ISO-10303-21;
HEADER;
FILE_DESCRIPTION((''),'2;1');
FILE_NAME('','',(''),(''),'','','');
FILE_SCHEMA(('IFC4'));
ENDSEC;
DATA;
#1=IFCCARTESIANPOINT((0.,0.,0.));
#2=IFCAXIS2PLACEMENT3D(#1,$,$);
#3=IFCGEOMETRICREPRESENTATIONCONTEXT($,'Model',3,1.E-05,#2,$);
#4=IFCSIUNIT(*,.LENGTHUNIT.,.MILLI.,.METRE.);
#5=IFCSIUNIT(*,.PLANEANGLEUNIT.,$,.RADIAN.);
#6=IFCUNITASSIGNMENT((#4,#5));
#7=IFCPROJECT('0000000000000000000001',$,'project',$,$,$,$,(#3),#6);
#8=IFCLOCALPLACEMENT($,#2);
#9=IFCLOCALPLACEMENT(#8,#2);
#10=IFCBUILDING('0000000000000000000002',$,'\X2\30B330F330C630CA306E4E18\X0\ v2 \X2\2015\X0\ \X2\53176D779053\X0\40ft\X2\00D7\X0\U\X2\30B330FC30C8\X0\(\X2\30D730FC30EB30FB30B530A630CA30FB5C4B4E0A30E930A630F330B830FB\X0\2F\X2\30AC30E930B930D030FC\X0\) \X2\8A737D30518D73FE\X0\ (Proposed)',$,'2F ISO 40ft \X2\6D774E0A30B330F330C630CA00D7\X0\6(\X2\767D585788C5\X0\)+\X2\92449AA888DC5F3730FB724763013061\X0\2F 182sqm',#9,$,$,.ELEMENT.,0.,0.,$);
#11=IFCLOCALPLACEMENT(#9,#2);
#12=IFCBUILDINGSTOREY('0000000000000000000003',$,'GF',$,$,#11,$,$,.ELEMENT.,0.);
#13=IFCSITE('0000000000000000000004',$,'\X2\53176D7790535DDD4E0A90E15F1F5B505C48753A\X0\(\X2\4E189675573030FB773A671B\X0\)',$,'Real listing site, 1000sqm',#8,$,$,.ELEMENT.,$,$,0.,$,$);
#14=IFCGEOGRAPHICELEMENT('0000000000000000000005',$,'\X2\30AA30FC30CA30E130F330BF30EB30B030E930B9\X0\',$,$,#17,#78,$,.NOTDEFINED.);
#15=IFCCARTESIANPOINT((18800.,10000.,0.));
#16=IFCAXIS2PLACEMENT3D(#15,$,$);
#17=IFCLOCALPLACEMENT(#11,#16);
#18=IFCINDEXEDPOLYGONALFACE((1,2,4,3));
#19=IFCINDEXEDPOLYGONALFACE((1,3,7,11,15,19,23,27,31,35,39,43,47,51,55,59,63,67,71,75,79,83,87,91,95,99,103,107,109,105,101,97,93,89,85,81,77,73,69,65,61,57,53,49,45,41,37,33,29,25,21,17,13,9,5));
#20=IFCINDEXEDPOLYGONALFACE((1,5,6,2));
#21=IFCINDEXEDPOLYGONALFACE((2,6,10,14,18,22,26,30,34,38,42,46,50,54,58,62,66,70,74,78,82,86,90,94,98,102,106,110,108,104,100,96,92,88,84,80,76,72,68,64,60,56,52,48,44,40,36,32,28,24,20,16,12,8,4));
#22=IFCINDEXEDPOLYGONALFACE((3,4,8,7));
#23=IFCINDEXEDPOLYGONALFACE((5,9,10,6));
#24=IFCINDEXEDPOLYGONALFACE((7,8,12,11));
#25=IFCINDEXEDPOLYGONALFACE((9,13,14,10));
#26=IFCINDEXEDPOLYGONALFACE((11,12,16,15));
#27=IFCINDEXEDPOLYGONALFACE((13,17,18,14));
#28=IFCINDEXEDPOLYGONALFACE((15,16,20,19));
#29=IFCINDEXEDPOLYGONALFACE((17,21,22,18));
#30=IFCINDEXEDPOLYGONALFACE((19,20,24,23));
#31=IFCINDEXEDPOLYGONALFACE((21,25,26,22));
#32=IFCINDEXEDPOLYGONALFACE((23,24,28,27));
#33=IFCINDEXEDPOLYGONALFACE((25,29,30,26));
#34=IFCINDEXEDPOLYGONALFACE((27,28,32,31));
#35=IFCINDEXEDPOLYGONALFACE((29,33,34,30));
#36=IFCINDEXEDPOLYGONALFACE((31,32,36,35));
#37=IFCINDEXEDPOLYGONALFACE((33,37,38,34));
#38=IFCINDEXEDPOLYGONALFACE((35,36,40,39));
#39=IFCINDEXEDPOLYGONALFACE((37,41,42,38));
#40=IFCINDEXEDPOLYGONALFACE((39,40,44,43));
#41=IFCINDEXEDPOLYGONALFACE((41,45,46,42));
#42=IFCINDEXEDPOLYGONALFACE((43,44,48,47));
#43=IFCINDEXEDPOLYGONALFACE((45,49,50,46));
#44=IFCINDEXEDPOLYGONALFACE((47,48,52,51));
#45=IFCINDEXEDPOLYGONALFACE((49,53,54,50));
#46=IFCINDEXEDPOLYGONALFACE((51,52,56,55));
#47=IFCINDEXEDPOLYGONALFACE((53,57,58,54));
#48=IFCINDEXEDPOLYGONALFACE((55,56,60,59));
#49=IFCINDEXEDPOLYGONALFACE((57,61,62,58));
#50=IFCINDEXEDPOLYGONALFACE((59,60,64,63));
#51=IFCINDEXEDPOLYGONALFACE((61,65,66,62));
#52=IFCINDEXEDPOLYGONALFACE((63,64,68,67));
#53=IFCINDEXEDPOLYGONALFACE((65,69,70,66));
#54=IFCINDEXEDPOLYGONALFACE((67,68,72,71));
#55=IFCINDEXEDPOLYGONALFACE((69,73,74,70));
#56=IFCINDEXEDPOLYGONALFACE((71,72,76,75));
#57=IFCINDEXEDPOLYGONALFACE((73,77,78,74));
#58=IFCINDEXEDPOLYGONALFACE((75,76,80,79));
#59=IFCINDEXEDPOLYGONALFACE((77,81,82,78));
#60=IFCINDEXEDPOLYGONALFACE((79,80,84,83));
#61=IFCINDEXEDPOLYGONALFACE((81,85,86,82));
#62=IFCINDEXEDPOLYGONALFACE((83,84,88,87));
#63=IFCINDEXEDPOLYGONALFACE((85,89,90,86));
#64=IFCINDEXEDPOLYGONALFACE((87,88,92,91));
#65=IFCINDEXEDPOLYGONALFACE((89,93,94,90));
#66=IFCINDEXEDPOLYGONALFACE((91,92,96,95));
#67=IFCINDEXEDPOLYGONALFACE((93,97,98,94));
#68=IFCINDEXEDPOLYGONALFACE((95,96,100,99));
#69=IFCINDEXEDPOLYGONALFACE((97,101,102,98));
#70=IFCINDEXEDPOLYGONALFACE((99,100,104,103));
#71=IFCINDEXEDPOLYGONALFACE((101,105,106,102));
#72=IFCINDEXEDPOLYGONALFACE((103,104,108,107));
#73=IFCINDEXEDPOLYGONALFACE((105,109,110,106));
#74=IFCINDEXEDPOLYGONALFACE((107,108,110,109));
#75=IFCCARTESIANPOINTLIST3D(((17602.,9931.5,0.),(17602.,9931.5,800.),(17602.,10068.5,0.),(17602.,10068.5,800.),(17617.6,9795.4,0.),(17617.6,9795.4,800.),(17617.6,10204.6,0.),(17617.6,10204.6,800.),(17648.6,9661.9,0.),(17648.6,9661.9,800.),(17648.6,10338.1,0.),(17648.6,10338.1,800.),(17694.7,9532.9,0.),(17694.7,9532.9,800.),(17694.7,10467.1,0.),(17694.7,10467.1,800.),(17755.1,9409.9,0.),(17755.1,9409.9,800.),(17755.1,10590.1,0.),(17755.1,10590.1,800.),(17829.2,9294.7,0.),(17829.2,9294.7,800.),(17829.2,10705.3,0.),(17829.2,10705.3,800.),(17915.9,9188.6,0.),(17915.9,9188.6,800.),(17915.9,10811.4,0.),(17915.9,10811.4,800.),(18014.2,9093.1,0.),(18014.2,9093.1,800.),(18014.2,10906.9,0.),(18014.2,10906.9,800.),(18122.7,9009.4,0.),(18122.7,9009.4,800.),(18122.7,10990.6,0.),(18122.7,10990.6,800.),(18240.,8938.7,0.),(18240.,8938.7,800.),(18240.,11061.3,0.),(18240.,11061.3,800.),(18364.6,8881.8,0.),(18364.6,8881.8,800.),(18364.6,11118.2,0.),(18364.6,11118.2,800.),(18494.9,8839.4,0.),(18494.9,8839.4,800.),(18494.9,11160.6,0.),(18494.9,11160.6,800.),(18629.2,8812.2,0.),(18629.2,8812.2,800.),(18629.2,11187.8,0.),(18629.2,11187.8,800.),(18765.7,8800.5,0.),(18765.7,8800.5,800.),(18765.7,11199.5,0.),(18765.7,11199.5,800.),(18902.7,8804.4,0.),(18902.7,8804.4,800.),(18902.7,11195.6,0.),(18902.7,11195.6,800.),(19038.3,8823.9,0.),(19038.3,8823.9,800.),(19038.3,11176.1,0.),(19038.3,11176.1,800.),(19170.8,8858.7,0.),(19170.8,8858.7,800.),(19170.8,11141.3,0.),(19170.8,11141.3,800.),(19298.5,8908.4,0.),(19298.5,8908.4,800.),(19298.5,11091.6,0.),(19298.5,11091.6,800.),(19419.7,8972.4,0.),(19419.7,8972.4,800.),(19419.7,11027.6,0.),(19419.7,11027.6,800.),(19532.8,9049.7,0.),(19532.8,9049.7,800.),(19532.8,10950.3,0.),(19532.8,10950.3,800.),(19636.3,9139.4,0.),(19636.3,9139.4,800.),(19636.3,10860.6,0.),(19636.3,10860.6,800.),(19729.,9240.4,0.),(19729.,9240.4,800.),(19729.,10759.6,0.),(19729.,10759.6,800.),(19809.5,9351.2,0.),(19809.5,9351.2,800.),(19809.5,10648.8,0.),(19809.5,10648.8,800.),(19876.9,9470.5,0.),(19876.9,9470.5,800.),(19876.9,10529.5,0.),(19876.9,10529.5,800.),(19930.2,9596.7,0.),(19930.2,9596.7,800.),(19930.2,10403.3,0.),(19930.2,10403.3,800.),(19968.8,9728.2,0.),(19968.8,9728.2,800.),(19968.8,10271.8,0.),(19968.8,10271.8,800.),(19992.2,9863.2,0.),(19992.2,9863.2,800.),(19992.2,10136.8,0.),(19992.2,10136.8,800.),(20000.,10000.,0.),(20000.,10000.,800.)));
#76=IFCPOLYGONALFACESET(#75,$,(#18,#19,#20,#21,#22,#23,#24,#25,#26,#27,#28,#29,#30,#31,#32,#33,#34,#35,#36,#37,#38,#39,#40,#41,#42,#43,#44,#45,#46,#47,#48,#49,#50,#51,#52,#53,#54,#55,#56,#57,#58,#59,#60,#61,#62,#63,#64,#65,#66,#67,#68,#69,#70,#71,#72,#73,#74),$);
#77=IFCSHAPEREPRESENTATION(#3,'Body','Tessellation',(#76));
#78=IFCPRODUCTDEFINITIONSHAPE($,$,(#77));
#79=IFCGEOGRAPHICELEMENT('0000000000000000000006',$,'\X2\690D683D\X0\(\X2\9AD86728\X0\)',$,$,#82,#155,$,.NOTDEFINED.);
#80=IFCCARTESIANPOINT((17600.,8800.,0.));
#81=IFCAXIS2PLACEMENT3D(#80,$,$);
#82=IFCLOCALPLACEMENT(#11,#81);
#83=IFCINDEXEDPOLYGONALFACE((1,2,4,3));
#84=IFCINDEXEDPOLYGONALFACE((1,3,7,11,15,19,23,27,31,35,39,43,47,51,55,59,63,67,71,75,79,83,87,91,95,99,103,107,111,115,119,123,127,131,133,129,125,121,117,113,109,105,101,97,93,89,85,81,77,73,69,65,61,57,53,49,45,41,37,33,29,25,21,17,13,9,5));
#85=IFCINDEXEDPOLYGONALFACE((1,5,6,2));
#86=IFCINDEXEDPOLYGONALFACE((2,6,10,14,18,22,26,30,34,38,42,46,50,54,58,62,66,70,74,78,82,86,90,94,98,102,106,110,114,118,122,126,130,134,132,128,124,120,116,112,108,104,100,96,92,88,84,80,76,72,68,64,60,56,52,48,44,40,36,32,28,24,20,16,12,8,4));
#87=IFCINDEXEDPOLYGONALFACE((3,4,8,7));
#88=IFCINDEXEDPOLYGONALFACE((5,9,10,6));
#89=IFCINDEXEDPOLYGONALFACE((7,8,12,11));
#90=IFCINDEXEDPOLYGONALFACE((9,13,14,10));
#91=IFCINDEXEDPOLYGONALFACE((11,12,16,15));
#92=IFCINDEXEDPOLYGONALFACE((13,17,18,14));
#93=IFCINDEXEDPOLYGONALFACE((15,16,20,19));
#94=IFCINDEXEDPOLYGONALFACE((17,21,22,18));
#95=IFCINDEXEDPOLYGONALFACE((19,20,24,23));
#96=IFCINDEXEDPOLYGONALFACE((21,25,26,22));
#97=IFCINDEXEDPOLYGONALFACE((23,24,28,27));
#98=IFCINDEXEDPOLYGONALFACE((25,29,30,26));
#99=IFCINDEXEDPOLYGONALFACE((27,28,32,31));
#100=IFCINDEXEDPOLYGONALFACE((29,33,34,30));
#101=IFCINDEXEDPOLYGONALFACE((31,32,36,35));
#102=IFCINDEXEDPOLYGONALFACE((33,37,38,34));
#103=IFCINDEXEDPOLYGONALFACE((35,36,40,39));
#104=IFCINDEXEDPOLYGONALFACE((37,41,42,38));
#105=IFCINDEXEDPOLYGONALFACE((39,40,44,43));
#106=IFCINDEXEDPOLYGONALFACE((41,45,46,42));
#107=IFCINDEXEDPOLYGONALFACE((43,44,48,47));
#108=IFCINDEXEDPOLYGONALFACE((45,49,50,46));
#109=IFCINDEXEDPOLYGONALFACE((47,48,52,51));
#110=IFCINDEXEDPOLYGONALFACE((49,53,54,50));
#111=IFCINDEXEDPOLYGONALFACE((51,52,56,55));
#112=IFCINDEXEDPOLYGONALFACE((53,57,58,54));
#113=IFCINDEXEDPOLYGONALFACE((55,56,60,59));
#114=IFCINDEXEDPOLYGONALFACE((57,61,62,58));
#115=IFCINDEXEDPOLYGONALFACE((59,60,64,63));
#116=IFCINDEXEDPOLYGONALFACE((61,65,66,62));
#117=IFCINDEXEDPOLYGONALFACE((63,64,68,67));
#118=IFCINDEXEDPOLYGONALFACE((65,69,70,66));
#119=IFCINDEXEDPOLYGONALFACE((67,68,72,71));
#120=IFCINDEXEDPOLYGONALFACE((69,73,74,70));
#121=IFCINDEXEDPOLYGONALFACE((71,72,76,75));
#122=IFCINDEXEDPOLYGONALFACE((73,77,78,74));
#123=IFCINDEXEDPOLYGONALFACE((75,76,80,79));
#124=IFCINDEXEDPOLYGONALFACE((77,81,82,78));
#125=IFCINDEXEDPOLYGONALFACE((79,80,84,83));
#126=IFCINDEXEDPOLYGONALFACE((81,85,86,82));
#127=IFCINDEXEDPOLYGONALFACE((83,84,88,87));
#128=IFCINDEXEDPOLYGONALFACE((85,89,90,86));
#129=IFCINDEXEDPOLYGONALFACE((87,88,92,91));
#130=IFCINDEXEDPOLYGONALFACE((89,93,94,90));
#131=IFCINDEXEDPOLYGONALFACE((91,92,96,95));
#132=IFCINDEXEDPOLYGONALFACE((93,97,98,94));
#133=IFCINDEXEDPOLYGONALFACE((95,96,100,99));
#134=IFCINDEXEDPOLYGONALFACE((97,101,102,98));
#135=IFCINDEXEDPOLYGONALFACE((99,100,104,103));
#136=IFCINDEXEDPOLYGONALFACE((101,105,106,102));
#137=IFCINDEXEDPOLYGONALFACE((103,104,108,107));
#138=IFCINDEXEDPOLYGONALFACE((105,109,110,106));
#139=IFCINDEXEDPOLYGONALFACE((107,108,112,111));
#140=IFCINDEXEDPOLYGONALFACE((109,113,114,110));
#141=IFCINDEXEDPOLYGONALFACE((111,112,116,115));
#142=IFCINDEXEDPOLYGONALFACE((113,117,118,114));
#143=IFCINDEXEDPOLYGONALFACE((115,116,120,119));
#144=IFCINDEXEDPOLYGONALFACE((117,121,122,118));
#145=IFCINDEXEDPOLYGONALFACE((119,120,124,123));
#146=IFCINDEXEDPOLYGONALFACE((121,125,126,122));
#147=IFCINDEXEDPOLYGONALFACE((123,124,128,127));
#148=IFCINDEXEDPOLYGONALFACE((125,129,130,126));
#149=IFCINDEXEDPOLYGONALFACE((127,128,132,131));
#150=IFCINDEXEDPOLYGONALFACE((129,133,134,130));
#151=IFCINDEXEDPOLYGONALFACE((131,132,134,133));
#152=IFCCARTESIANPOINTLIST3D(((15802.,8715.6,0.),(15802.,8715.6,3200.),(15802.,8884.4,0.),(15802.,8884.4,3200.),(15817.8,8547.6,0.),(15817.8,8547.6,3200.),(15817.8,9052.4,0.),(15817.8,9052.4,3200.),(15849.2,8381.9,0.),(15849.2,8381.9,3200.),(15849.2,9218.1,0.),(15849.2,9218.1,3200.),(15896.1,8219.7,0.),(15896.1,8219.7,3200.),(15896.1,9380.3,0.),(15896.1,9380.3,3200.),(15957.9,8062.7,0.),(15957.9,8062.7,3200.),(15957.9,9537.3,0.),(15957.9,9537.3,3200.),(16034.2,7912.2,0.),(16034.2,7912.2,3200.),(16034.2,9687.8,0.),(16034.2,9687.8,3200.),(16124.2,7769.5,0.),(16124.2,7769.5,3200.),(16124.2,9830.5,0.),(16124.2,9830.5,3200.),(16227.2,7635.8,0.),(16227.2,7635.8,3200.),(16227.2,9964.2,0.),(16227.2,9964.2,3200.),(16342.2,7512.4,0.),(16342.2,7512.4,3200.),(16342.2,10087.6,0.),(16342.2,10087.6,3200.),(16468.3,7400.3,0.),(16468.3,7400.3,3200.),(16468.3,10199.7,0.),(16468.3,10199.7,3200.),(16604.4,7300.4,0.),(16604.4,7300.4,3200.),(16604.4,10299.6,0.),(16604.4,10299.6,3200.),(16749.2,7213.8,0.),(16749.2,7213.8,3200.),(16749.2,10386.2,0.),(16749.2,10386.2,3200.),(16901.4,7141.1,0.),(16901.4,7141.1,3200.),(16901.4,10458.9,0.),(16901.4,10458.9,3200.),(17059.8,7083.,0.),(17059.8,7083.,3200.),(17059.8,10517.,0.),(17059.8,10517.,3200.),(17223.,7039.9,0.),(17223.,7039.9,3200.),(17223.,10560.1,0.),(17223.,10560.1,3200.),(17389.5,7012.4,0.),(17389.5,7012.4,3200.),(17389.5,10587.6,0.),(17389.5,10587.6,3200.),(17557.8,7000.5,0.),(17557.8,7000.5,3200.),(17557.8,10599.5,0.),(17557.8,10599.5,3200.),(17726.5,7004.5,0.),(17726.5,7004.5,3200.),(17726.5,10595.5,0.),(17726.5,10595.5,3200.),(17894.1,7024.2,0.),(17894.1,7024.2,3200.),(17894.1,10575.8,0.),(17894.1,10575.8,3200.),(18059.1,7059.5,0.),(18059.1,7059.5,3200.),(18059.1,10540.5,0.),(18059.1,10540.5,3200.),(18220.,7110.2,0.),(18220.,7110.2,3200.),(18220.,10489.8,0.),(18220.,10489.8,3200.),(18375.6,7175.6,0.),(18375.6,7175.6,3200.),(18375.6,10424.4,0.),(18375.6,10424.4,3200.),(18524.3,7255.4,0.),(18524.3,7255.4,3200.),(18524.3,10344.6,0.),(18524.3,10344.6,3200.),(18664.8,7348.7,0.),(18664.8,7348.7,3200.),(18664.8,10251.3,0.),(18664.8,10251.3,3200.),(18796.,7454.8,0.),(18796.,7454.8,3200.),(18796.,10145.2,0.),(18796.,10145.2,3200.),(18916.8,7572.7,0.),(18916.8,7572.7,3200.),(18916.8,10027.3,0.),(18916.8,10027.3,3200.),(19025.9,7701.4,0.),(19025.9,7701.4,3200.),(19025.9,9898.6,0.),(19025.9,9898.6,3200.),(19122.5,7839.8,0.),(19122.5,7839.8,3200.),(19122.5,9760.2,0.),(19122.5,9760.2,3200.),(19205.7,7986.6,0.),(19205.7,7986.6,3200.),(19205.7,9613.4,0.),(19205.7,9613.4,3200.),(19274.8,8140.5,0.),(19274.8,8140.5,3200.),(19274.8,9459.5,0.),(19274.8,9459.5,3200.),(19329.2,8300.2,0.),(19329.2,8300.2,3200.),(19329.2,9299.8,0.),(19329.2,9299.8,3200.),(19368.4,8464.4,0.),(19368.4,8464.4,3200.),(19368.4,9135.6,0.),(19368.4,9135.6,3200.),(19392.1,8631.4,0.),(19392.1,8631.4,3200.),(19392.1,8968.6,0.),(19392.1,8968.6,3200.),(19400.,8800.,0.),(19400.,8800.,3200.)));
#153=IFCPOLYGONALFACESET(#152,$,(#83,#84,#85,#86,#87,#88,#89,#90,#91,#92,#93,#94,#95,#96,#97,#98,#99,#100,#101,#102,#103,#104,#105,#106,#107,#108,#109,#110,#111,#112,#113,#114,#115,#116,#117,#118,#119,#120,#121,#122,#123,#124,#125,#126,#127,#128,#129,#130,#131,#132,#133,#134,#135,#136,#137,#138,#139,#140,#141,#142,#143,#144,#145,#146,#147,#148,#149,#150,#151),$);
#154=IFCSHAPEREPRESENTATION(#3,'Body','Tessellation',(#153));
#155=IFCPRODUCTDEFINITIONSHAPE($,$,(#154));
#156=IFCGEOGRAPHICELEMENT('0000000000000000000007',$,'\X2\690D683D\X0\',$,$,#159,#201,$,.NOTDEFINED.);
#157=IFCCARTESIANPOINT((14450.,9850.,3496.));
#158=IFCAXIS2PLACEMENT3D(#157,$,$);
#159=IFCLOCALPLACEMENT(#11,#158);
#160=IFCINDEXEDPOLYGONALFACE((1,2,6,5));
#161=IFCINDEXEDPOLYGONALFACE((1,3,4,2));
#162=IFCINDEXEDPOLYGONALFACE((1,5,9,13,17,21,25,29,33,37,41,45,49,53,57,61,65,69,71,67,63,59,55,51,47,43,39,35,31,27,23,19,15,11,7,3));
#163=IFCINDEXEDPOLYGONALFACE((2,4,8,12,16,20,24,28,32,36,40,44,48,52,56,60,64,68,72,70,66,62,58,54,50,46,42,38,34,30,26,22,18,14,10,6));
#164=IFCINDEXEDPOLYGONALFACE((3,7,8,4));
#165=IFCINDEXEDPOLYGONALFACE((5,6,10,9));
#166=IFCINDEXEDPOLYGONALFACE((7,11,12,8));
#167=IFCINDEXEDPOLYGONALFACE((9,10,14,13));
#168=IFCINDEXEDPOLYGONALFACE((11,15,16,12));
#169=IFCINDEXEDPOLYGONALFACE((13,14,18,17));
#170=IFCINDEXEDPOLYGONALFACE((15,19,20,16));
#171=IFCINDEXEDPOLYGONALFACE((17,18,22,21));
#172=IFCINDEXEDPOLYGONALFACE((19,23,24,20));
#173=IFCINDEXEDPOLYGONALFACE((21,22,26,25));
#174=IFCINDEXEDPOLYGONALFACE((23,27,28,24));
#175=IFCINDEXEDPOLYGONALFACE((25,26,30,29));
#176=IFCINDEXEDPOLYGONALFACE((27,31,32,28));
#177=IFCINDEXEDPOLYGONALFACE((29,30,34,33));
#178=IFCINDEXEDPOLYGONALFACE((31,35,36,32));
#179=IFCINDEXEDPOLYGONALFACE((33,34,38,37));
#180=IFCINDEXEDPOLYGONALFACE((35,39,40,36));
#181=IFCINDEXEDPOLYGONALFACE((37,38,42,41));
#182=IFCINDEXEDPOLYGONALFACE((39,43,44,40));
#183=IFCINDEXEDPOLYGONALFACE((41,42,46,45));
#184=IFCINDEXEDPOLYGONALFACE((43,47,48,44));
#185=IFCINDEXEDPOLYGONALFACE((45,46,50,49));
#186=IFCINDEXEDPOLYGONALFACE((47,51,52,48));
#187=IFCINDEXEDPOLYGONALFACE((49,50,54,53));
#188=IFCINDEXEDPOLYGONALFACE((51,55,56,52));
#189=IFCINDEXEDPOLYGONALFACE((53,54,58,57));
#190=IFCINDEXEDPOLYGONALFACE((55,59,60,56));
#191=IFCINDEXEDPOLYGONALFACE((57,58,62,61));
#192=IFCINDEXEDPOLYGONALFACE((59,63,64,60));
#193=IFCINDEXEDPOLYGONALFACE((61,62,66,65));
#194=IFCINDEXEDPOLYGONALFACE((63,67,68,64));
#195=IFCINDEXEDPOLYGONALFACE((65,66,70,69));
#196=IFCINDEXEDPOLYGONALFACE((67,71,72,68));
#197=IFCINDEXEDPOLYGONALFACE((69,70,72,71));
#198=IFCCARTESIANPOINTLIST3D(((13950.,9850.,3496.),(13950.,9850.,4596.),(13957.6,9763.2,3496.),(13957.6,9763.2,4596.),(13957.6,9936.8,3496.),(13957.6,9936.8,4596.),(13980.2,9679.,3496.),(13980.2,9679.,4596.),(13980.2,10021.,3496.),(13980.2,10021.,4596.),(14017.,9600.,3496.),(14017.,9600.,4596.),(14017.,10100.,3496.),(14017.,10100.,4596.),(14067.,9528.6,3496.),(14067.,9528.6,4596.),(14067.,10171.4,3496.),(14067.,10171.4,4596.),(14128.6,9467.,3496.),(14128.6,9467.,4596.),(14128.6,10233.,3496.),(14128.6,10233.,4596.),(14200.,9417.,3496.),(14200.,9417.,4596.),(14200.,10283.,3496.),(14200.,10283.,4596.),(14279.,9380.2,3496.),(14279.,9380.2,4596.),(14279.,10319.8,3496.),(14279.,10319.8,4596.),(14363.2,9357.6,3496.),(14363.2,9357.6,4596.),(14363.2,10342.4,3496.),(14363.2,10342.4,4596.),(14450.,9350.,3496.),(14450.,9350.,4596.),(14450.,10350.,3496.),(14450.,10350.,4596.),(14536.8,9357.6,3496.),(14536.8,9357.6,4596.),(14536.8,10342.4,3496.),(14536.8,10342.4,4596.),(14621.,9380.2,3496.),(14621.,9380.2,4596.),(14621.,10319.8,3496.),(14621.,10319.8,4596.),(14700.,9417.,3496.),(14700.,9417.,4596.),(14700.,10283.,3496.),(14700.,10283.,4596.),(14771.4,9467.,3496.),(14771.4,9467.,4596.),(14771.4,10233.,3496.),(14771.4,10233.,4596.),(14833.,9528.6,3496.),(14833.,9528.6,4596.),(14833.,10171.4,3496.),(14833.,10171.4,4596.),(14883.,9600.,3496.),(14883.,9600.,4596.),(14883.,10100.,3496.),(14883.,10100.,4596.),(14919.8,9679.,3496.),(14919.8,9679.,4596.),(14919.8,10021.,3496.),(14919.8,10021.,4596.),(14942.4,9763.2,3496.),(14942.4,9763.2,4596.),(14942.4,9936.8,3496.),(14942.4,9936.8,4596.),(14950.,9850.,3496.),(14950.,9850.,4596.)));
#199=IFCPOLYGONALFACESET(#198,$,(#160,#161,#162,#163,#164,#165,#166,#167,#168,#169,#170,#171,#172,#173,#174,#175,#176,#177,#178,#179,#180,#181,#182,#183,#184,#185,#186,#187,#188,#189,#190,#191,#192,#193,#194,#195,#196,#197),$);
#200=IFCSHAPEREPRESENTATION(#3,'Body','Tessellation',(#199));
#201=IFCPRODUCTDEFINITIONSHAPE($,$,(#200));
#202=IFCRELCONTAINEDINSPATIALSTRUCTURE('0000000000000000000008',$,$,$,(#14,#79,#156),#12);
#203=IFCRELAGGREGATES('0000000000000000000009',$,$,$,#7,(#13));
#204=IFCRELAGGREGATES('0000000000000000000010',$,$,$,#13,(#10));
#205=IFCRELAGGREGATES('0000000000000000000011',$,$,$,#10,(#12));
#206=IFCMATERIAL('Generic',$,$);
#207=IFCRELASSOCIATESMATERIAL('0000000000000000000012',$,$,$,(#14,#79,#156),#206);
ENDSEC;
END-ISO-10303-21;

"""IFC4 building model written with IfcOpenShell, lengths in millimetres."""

from ifc_helpers import new_model, si_unit, frame, origin, origin_2d, place, context, project, spatial, circle, extrude, material, element, save


model = new_model("IFC4")

# Units and contexts
model_context = context("Model", 3, precision=1e-05, world=origin())
ifc_project = project(units=[si_unit("LENGTHUNIT", "METRE", prefix="MILLI"), si_unit("PLANEANGLEUNIT", "RADIAN")], contexts=[model_context])

# Site, building, storey
site_placement = place(None, origin())
site = spatial("IfcSite", under=ifc_project, at=site_placement, Name="北海道川上郡弟子屈町(丘陵地・眺望)", ObjectType="Real listing site, 1000sqm", CompositionType="ELEMENT", RefElevation=0.0)
building_placement = place(site_placement, origin())
building = spatial("IfcBuilding", under=site, at=building_placement, Name="コンテナの丘 v2 ― 北海道40ft×Uコート(プール・サウナ・屋上ラウンジ・2Fガラスバー) 詳細再現 (Proposed)", ObjectType="2F ISO 40ft 海上コンテナ×6(白塗装)+鉄骨補強・片持ち2F 182sqm", CompositionType="ELEMENT", ElevationOfRefHeight=0.0, ElevationOfTerrain=0.0)
storey_placement = place(building_placement, origin())
storey = spatial("IfcBuildingStorey", under=building, at=storey_placement, Name="GF", CompositionType="ELEMENT", Elevation=0.0)

# Shared definitions
ifc_material = material(Name="Generic")

# Geographic elements
geographic_element_1_placement = place(storey_placement, frame((18800.0, 10000.0, 0.0)))
element("IfcGeographicElement", 1, at=geographic_element_1_placement, inside=storey, material=ifc_material, Name="オーナメンタルグラス", PredefinedType="NOTDEFINED", context=model_context, shape_type="SweptSolid", body=[
    extrude(circle(Radius=1200.0, at=origin_2d()), frame((18800.0, 10000.0, 0.0)), (0.0, 0.0, 1.0), 800.0),
])
geographic_element_2_placement = place(storey_placement, frame((17600.0, 8800.0, 0.0)))
element("IfcGeographicElement", 2, at=geographic_element_2_placement, inside=storey, material=ifc_material, Name="植栽(高木)", PredefinedType="NOTDEFINED", context=model_context, shape_type="SweptSolid", body=[
    extrude(circle(Radius=1800.0, at=origin_2d()), frame((17600.0, 8800.0, 0.0)), (0.0, 0.0, 1.0), 3200.0),
])
geographic_element_3_placement = place(storey_placement, frame((14450.0, 9850.0, 3496.0)))
element("IfcGeographicElement", 3, at=geographic_element_3_placement, inside=storey, material=ifc_material, Name="植栽", PredefinedType="NOTDEFINED", context=model_context, shape_type="SweptSolid", body=[
    extrude(circle(Radius=500.0, at=origin_2d()), frame((14450.0, 9850.0, 3496.0)), (0.0, 0.0, 1.0), 1100.0),
])

save(model, "model.ifc")
